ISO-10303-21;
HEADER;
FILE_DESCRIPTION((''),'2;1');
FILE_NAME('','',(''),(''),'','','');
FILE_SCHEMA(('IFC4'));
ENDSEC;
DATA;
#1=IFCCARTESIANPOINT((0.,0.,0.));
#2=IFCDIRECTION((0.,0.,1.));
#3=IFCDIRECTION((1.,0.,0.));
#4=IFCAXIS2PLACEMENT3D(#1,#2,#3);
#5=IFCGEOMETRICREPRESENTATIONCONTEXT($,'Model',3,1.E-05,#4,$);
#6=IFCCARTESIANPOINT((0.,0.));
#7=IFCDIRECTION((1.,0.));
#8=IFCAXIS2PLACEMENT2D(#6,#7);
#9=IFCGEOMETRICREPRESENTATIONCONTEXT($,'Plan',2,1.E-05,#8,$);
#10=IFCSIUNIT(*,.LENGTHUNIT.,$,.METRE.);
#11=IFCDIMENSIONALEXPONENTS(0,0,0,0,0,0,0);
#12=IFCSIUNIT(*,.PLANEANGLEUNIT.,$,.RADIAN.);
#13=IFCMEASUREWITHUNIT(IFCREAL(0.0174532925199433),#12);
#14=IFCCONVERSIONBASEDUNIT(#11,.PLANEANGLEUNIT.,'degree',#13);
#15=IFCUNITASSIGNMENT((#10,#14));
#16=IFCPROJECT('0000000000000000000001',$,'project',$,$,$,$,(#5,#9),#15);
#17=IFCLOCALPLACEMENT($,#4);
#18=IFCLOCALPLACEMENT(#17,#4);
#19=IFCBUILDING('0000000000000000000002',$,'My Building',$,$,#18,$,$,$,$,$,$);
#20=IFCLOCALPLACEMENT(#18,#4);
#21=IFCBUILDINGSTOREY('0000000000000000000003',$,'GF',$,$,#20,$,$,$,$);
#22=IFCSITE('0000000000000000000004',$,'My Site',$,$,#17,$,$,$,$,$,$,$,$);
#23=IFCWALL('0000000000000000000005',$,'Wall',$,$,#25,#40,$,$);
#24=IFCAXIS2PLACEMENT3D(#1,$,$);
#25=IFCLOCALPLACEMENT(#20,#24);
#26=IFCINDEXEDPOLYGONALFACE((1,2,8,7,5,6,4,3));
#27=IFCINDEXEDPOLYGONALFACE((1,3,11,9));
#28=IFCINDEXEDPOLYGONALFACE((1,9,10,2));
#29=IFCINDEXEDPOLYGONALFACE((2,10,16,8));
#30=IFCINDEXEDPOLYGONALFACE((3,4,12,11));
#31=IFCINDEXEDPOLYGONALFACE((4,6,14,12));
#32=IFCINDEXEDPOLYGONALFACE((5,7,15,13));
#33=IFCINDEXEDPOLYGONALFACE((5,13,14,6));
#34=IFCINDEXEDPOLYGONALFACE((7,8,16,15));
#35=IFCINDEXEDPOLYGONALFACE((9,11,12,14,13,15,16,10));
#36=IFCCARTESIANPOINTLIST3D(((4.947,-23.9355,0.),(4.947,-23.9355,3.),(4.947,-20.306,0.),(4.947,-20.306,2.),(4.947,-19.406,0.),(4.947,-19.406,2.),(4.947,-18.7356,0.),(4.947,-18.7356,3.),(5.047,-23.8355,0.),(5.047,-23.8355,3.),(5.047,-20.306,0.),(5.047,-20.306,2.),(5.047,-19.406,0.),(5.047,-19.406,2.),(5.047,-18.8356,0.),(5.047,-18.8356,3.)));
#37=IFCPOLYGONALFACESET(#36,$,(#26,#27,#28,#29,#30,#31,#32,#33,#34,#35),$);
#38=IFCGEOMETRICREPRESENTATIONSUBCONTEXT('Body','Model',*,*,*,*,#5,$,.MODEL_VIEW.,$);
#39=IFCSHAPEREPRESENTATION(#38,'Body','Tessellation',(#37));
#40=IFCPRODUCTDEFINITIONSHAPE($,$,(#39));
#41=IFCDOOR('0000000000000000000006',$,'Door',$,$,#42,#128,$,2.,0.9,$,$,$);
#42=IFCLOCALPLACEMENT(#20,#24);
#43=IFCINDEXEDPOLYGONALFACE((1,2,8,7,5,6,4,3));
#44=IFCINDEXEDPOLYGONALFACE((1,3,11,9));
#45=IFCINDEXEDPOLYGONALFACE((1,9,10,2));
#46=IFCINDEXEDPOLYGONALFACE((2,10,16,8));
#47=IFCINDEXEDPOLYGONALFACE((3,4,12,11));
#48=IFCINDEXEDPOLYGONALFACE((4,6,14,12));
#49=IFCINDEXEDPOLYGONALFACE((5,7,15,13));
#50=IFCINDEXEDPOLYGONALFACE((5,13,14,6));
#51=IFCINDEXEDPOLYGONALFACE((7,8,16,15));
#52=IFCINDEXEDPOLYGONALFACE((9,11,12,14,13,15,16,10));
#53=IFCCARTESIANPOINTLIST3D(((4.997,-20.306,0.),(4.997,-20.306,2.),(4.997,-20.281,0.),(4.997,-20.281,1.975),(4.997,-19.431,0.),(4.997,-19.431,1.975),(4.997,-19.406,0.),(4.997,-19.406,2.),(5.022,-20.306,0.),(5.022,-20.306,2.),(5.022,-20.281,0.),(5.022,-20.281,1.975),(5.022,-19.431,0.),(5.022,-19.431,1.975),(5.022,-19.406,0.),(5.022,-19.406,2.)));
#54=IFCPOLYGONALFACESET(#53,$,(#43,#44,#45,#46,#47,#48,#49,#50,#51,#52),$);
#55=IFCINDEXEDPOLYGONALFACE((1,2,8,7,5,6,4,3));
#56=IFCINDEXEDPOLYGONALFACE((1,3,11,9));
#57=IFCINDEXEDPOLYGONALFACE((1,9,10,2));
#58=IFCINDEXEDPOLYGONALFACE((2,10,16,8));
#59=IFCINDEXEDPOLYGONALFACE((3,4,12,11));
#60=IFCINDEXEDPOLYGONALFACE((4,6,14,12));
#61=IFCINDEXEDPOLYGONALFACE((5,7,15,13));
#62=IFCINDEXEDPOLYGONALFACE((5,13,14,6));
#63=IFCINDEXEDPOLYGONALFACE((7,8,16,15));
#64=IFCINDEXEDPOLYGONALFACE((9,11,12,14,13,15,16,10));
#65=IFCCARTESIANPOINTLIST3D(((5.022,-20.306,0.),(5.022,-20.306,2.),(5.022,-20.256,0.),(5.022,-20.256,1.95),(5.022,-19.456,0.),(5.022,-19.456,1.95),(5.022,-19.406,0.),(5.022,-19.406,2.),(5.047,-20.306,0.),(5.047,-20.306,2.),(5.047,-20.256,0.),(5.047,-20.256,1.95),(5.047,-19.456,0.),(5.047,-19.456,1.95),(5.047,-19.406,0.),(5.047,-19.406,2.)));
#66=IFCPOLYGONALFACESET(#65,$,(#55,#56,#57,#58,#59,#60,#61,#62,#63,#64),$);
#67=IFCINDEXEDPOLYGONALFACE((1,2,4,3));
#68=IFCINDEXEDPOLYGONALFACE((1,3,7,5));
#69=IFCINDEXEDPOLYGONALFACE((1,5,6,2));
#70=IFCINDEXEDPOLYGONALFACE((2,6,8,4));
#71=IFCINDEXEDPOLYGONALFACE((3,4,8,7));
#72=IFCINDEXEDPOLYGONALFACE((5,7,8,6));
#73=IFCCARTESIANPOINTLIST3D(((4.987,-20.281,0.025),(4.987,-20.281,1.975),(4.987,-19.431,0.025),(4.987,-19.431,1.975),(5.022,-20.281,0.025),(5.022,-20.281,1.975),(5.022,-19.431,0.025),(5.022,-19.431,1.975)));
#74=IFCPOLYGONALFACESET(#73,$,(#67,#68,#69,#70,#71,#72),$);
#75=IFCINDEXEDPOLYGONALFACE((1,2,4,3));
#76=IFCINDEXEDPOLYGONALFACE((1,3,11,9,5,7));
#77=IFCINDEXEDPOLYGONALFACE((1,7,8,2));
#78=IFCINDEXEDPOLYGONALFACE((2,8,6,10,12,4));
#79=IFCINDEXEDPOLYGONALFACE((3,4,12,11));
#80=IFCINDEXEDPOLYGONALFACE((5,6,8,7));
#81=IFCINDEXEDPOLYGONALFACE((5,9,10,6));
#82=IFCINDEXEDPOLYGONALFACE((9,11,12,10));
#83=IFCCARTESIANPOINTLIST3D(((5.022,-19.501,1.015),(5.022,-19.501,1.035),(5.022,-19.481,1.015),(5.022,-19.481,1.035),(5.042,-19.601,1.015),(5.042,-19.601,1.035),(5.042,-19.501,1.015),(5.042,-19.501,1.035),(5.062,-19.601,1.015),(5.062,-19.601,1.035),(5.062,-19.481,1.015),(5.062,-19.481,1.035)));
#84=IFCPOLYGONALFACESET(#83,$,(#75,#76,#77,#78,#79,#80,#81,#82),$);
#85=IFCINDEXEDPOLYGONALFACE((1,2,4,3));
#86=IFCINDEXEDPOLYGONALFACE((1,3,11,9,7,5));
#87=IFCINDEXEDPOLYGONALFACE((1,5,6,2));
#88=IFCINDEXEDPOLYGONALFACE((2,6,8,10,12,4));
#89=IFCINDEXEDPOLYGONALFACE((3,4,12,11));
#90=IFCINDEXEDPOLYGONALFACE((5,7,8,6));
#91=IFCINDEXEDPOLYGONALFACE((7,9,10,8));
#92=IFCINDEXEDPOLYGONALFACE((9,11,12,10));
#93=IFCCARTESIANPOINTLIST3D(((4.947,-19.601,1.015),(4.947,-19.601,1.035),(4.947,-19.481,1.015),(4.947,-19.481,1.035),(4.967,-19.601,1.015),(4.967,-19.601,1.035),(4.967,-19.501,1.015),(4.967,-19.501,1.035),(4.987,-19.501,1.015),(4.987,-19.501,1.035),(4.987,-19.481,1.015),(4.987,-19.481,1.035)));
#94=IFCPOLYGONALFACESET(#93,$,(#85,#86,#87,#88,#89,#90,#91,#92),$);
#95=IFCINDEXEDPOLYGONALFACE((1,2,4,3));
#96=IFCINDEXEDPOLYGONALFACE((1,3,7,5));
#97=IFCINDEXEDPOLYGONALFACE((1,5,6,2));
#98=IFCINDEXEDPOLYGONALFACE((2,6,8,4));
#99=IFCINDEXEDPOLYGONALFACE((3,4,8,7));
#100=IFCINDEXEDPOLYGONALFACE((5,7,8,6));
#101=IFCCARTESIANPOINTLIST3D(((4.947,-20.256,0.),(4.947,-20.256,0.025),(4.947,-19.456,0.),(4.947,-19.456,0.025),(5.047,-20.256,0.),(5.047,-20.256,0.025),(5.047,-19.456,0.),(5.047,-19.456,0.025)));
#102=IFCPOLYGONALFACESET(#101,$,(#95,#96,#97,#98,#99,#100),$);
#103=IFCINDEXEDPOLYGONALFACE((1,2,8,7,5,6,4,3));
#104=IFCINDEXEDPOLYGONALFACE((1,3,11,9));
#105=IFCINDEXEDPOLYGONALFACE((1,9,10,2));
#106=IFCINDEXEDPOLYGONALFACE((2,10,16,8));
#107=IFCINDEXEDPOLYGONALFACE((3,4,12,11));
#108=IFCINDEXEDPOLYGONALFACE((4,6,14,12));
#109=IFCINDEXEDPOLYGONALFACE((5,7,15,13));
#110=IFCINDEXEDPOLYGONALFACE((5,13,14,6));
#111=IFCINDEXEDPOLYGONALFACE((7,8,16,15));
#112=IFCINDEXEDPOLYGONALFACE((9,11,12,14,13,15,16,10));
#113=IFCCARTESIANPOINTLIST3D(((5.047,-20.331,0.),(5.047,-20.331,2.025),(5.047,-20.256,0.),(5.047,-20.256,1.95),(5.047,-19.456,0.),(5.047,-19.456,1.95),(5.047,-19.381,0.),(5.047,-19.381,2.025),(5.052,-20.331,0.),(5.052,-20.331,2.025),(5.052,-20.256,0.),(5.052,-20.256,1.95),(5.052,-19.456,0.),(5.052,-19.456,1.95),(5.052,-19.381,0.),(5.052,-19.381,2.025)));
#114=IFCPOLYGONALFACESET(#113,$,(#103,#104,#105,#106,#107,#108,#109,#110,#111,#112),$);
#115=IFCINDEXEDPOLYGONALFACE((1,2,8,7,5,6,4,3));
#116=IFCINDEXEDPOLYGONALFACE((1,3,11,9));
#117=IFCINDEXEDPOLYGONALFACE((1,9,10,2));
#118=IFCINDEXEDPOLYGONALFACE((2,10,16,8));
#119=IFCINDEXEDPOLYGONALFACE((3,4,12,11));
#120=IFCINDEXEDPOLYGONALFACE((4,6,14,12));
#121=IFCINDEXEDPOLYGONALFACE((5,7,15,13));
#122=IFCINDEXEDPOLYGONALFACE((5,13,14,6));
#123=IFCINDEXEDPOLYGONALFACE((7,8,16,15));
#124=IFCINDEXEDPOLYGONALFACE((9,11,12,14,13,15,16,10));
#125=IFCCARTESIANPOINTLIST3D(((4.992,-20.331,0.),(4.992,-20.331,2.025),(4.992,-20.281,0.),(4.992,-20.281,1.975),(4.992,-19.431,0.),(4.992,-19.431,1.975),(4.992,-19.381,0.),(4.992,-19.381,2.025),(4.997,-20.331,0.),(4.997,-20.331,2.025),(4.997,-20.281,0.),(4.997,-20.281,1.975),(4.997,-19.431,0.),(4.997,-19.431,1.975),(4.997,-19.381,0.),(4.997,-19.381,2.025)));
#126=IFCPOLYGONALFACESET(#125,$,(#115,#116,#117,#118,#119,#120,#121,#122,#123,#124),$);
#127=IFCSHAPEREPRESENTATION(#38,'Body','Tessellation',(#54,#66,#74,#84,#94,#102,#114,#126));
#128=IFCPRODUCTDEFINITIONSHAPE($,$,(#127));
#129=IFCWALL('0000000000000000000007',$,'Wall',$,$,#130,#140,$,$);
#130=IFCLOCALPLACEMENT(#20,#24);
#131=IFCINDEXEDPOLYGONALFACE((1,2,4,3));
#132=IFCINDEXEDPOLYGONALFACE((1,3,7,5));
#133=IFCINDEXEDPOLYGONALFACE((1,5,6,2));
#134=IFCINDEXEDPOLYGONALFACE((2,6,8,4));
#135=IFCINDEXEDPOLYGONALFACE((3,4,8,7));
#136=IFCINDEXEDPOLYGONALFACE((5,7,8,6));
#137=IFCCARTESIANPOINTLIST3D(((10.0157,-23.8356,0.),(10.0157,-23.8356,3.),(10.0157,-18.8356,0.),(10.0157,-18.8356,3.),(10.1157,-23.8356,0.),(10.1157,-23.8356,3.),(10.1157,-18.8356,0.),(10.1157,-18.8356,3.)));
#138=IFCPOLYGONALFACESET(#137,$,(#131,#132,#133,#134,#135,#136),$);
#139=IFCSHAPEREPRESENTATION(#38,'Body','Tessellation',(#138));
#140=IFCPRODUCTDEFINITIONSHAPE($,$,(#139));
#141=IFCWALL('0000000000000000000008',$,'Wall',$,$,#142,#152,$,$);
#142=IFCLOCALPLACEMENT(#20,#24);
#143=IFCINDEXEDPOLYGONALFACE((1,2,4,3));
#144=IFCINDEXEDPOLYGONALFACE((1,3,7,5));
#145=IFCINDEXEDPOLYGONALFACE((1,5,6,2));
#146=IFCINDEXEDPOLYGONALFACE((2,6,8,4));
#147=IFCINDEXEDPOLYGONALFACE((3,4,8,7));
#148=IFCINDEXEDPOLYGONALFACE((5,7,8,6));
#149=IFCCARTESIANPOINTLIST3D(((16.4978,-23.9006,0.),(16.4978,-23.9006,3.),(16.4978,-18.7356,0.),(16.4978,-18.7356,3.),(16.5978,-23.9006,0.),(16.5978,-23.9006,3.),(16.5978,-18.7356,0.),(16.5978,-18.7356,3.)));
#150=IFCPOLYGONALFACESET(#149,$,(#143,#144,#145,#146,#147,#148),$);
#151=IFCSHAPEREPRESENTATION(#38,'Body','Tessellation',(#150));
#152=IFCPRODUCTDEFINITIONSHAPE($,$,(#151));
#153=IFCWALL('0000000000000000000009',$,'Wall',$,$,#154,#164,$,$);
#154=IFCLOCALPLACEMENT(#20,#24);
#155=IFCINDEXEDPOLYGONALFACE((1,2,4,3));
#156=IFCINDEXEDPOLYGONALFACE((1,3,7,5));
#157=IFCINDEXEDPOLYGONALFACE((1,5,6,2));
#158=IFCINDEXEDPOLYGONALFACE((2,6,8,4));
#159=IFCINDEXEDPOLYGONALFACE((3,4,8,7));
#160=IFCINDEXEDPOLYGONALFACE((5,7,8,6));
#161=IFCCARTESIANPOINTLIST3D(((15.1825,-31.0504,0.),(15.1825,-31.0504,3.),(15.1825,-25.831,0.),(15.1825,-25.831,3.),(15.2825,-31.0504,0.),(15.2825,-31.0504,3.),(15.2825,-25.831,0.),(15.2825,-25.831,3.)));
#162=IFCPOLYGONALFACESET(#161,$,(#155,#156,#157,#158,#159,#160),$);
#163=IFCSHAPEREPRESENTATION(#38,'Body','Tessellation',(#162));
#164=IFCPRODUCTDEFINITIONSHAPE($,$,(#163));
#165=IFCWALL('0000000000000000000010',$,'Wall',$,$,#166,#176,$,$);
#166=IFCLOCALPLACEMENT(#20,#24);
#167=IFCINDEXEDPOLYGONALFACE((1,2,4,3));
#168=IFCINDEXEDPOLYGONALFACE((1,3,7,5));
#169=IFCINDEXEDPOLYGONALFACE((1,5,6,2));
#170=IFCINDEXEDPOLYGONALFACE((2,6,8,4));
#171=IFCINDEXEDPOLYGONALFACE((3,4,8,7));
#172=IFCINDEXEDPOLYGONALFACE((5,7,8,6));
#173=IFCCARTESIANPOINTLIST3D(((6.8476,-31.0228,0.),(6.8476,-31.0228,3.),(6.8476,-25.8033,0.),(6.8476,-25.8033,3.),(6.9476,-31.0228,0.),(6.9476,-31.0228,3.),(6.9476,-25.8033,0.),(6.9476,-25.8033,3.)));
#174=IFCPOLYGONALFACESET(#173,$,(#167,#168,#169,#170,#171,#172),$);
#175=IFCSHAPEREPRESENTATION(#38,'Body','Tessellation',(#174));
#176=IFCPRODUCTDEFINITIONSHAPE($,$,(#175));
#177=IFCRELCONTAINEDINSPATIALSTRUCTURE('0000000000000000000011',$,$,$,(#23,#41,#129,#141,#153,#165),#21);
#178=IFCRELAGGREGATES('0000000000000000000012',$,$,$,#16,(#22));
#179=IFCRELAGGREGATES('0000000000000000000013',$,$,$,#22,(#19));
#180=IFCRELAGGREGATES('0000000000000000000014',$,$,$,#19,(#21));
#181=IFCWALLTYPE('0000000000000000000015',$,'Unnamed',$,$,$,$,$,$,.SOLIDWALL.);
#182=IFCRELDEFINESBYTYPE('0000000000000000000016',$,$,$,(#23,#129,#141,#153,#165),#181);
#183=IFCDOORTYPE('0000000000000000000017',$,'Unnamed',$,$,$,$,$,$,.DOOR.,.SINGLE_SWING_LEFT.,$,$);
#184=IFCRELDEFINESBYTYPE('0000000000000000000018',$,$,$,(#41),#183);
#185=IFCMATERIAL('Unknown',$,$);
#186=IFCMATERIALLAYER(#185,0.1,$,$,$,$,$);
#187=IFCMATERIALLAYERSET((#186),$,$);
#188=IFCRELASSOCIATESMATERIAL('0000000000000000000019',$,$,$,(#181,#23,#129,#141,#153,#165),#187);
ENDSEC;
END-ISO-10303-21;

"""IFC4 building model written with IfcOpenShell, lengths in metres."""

from ifc_helpers import new_model, entity, si_unit, converted_unit, frame, origin_with_axes, origin_2d_with_axis, place, context, subcontext, project, spatial, line, indexed_curve, outline, extrude, shape, source, transform, mapped, material, layer, layer_set, layer_usage, type_object, type_shapes, element, fill, save


model = new_model("IFC4")

# Units and contexts
model_context = context("Model", 3, precision=1e-05, world=origin_with_axes())
plan_context = context("Plan", 2, precision=1e-05, world=origin_2d_with_axis())
body_context_1 = subcontext(model_context, "Body", "Model", "MODEL_VIEW")
body_context_2 = subcontext(plan_context, "Body", "Plan", "PLAN_VIEW")
ifc_project = project(units=[si_unit("LENGTHUNIT", "METRE"), converted_unit("PLANEANGLEUNIT", "degree", entity("IfcReal", 0.0174532925199433), si_unit("PLANEANGLEUNIT", "RADIAN"), dimensions=[0, 0, 0, 0, 0, 0, 0])], contexts=[model_context, plan_context])

# Site, building, storey
site_placement = place(None, origin_with_axes())
site = spatial("IfcSite", under=ifc_project, at=site_placement, Name="My Site")
building_placement = place(site_placement, origin_with_axes())
building = spatial("IfcBuilding", under=site, at=building_placement, Name="My Building")
storey_placement = place(building_placement, origin_with_axes())
storey = spatial("IfcBuildingStorey", under=building, at=storey_placement, Name="GF")

# Shared definitions
ifc_material = material(Name="Unknown")

# Shared definitions
ifc_layer_1 = layer(ifc_material, 0.1)
ifc_layer_set_1 = layer_set([ifc_layer_1])
wall_type = type_object("IfcWallType", Name="Unnamed", PredefinedType="SOLIDWALL", material=ifc_layer_set_1)

# Shared definitions
shared_shape_1 = source(origin_with_axes(), body_context_1, "Body", "SweptSolid", [
    extrude(outline(indexed_curve([(0.0, 0.0), (0.9, 0.0), (0.9, 2.0), (0.0, 2.0)], segments=[line(1, 2, 3, 4, 1)])), frame((0.0, -0.6, 0.0), z_axis=(0.0, -1.0, 0.0), x_axis=(1.0, 0.0, 0.0)), (0.0, 0.0, -1.0), 1.2),
])
door_type = type_object("IfcDoorType", Name="Unnamed", OperationType="SINGLE_SWING_LEFT", PredefinedType="DOOR")
shared_shape_2 = source(origin_with_axes(), body_context_1, "Body", "SweptSolid", [
    extrude(outline(indexed_curve([(0.0, 0.0), (0.0, 2.0), (0.9, 2.0), (0.9, 0.0), (0.875, 0.0), (0.875, 1.975), (0.025, 1.975), (0.025, 0.0)], segments=[line(1, 2, 3, 4, 5, 6, 7, 8, 1)])), frame((0.0, 0.025, 0.0), z_axis=(0.0, -1.0, 0.0), x_axis=(1.0, 0.0, 0.0)), (0.0, 0.0, -1.0), 0.025),
    extrude(outline(indexed_curve([(0.0, 0.0), (0.0, 2.0), (0.9, 2.0), (0.9, 0.0), (0.85, 0.0), (0.85, 1.95), (0.05, 1.95), (0.05, 0.0)], segments=[line(1, 2, 3, 4, 5, 6, 7, 8, 1)])), frame((0.0, 0.0, 0.0), z_axis=(0.0, -1.0, 0.0), x_axis=(1.0, 0.0, 0.0)), (0.0, 0.0, -1.0), 0.025),
    extrude(outline(indexed_curve([(0.0, 0.0), (0.85, 0.0), (0.85, 0.035), (0.0, 0.035)], segments=[line(1, 2, 3, 4, 1)])), frame((0.025, 0.025, 0.025), z_axis=(0.0, 0.0, 1.0), x_axis=(1.0, 0.0, 0.0)), (0.0, 0.0, 1.0), 1.95),
    extrude(outline(indexed_curve([(0.0, 0.0), (0.0, -0.04), (-0.12, -0.04), (-0.12, -0.02), (-0.02, -0.02), (-0.02, 0.0)], segments=[line(1, 2, 3, 4, 5, 6, 1)])), frame((0.825, 0.025, 1.015), z_axis=(0.0, 0.0, 1.0), x_axis=(1.0, 0.0, 0.0)), (0.0, 0.0, 1.0), 0.02),
    extrude(outline(indexed_curve([(0.0, 0.0), (0.0, 0.04), (-0.12, 0.04), (-0.12, 0.02), (-0.02, 0.02), (-0.02, 0.0)], segments=[line(1, 2, 3, 4, 5, 6, 1)])), frame((0.825, 0.06, 1.015), z_axis=(0.0, 0.0, 1.0), x_axis=(1.0, 0.0, 0.0)), (0.0, 0.0, 1.0), 0.02),
    extrude(outline(indexed_curve([(0.0, 0.0), (0.8, 0.0), (0.8, 0.1), (0.0, 0.1)], segments=[line(1, 2, 3, 4, 1)])), frame((0.05, 0.0, 0.0), z_axis=(0.0, 0.0, 1.0), x_axis=(1.0, 0.0, 0.0)), (0.0, 0.0, 1.0), 0.025),
    extrude(outline(indexed_curve([(0.0, 0.0), (0.0, 2.025), (0.95, 2.025), (0.95, 0.0), (0.875, 0.0), (0.875, 1.95), (0.075, 1.95), (0.075, 0.0)], segments=[line(1, 2, 3, 4, 5, 6, 7, 8, 1)])), frame((-0.025, -0.005, 0.0), z_axis=(0.0, -1.0, 0.0), x_axis=(1.0, 0.0, 0.0)), (0.0, 0.0, -1.0), 0.005),
    extrude(outline(indexed_curve([(0.0, 0.0), (0.0, 2.025), (0.95, 2.025), (0.95, 0.0), (0.9, 0.0), (0.9, 1.975), (0.05, 1.975), (0.05, 0.0)], segments=[line(1, 2, 3, 4, 5, 6, 7, 8, 1)])), frame((-0.025, 0.05, 0.0), z_axis=(0.0, -1.0, 0.0), x_axis=(1.0, 0.0, 0.0)), (0.0, 0.0, -1.0), 0.005),
])
shared_shape_3 = source(origin_with_axes(), body_context_2, "Body", "Curve2D", [
    entity("IfcIndexedPolyCurve", entity("IfcCartesianPointList2D", [[0.0, 0.0], [0.0, 0.05], [0.025, 0.05], [0.025, 0.025], [0.05, 0.025], [0.05, 0.0]]), [entity("IfcLineIndex", [1, 2, 3, 4, 5, 6, 1])]),
    entity("IfcIndexedPolyCurve", entity("IfcCartesianPointList2D", [[0.9, 0.0], [0.9, 0.05], [0.875, 0.05], [0.875, 0.025], [0.85, 0.025], [0.85, 0.0]]), [entity("IfcLineIndex", [1, 2, 3, 4, 5, 6, 1])]),
    entity("IfcTrimmedCurve", entity("IfcEllipse", entity("IfcAxis2Placement2D", entity("IfcCartesianPoint", [0.06, 0.05]), entity("IfcDirection", [1.0, 0.0])), 0.815, 0.85), [entity("IfcCartesianPoint", [0.875, 0.05])], [entity("IfcCartesianPoint", [0.06, 0.9])], True, "CARTESIAN"),
    entity("IfcIndexedPolyCurve", entity("IfcCartesianPointList2D", [[0.025, 0.05], [0.06, 0.05], [0.06, 0.9], [0.025, 0.9]]), [entity("IfcLineIndex", [1, 2, 3, 4, 1])]),
])
type_shapes(door_type, [shared_shape_2, shared_shape_3])

# Wall, opening, door
ifc_layer_usage_1 = layer_usage(ifc_layer_set_1, "AXIS2", "POSITIVE", 0.0)
wall_1_placement = place(storey_placement, frame((5.047, -23.8355, 0.0), z_axis=(0.0, 0.0, 1.0), x_axis=(0.0, 1.0, 0.0)))
wall_1 = element("IfcWall", 1, at=wall_1_placement, inside=storey, type_object=wall_type, material=ifc_layer_usage_1, Name="Wall", context=body_context_1, shape_type="SweptSolid", body=[
    extrude(outline(indexed_curve([(0.0, 0.0), (-0.1, 0.1), (5.1, 0.1), (5.0, 0.0)], segments=[line(1, 2, 3, 4, 1)])), origin_with_axes(), (0.0, 0.0, 1.0), 3.0),
])
opening_1_placement = place(wall_1_placement, frame((3.5295, 0.0, 0.0), z_axis=(0.0, 0.0, 1.0), x_axis=(1.0, 0.0, 0.0)))
opening_1 = element("IfcOpeningElement", 2, at=opening_1_placement, cuts=wall_1, PredefinedType="OPENING", context=body_context_1, shape_type="MappedRepresentation", body=[
    mapped(shared_shape_1, transform((0.0, 0.0, 0.0), x_axis=(1.0, 0.0, 0.0), y_axis=(0.0, 1.0, 0.0), z_axis=(0.0, 0.0, 1.0), scale=1.0)),
])
door_1_placement = place(opening_1_placement, frame((0.0, 0.0, 0.0), z_axis=(0.0, 0.0, 1.0), x_axis=(1.0, 0.0, 0.0)))
door_1 = element("IfcDoor", 3, at=door_1_placement, inside=storey, type_object=door_type, Name="Door", OverallHeight=2.0, OverallWidth=0.9, shapes=[
    shape(body_context_1, "Body", "MappedRepresentation", [mapped(shared_shape_2, transform((0.0, 0.0, 0.0), x_axis=(1.0, 0.0, 0.0), y_axis=(0.0, 1.0, 0.0), z_axis=(0.0, 0.0, 1.0), scale=1.0))]),
    shape(body_context_2, "Body", "MappedRepresentation", [mapped(shared_shape_3, transform((0.0, 0.0, 0.0), x_axis=(1.0, 0.0, 0.0), y_axis=(0.0, 1.0, 0.0), z_axis=(0.0, 0.0, 1.0), scale=1.0))]),
])
fill(opening_1, door_1)

# Walls
ifc_layer_usage_2 = layer_usage(ifc_layer_set_1, "AXIS2", "POSITIVE", 0.0)
wall_2_placement = place(storey_placement, frame((10.0157, -18.8356, 0.0), z_axis=(0.0, 0.0, 1.0), x_axis=(0.0, -1.0, 0.0)))
element("IfcWall", 4, at=wall_2_placement, inside=storey, type_object=wall_type, material=ifc_layer_usage_2, Name="Wall", context=body_context_1, shape_type="SweptSolid", body=[
    extrude(outline(indexed_curve([(0.0, 0.0), (0.0, 0.1), (5.0, 0.1), (5.0, 0.0)], segments=[line(1, 2, 3, 4, 1)])), origin_with_axes(), (0.0, 0.0, 1.0), 3.0),
])
ifc_layer_usage_3 = layer_usage(ifc_layer_set_1, "AXIS2", "POSITIVE", 0.0)
wall_3_placement = place(storey_placement, frame((16.4978, -18.7356, 0.0), z_axis=(0.0, 0.0, 1.0), x_axis=(0.0, -1.0, 0.0)))
element("IfcWall", 5, at=wall_3_placement, inside=storey, type_object=wall_type, material=ifc_layer_usage_3, Name="Wall", context=body_context_1, shape_type="SweptSolid", body=[
    extrude(outline(indexed_curve([(0.0, 0.0), (0.0, 0.1), (5.1651, 0.1), (5.1651, 0.0)], segments=[line(1, 2, 3, 4, 1)])), origin_with_axes(), (0.0, 0.0, 1.0), 3.0),
])
ifc_layer_usage_4 = layer_usage(ifc_layer_set_1, "AXIS2", "POSITIVE", 0.0)
wall_4_placement = place(storey_placement, frame((15.1825, -25.831, 0.0), z_axis=(0.0, 0.0, 1.0), x_axis=(0.0, -1.0, 0.0)))
element("IfcWall", 6, at=wall_4_placement, inside=storey, type_object=wall_type, material=ifc_layer_usage_4, Name="Wall", context=body_context_1, shape_type="SweptSolid", body=[
    extrude(outline(indexed_curve([(0.0, 0.0), (0.0, 0.1), (5.2194, 0.1), (5.2194, 0.0)], segments=[line(1, 2, 3, 4, 1)])), origin_with_axes(), (0.0, 0.0, 1.0), 3.0),
])
ifc_layer_usage_5 = layer_usage(ifc_layer_set_1, "AXIS2", "POSITIVE", 0.0)
wall_5_placement = place(storey_placement, frame((6.8476, -25.8033, 0.0), z_axis=(0.0, 0.0, 1.0), x_axis=(0.0, -1.0, 0.0)))
element("IfcWall", 7, at=wall_5_placement, inside=storey, type_object=wall_type, material=ifc_layer_usage_5, Name="Wall", context=body_context_1, shape_type="SweptSolid", body=[
    extrude(outline(indexed_curve([(0.0, 0.0), (0.0, 0.1), (5.2195, 0.1), (5.2195, 0.0)], segments=[line(1, 2, 3, 4, 1)])), origin_with_axes(), (0.0, 0.0, 1.0), 3.0),
])

save(model, "model.ifc")
